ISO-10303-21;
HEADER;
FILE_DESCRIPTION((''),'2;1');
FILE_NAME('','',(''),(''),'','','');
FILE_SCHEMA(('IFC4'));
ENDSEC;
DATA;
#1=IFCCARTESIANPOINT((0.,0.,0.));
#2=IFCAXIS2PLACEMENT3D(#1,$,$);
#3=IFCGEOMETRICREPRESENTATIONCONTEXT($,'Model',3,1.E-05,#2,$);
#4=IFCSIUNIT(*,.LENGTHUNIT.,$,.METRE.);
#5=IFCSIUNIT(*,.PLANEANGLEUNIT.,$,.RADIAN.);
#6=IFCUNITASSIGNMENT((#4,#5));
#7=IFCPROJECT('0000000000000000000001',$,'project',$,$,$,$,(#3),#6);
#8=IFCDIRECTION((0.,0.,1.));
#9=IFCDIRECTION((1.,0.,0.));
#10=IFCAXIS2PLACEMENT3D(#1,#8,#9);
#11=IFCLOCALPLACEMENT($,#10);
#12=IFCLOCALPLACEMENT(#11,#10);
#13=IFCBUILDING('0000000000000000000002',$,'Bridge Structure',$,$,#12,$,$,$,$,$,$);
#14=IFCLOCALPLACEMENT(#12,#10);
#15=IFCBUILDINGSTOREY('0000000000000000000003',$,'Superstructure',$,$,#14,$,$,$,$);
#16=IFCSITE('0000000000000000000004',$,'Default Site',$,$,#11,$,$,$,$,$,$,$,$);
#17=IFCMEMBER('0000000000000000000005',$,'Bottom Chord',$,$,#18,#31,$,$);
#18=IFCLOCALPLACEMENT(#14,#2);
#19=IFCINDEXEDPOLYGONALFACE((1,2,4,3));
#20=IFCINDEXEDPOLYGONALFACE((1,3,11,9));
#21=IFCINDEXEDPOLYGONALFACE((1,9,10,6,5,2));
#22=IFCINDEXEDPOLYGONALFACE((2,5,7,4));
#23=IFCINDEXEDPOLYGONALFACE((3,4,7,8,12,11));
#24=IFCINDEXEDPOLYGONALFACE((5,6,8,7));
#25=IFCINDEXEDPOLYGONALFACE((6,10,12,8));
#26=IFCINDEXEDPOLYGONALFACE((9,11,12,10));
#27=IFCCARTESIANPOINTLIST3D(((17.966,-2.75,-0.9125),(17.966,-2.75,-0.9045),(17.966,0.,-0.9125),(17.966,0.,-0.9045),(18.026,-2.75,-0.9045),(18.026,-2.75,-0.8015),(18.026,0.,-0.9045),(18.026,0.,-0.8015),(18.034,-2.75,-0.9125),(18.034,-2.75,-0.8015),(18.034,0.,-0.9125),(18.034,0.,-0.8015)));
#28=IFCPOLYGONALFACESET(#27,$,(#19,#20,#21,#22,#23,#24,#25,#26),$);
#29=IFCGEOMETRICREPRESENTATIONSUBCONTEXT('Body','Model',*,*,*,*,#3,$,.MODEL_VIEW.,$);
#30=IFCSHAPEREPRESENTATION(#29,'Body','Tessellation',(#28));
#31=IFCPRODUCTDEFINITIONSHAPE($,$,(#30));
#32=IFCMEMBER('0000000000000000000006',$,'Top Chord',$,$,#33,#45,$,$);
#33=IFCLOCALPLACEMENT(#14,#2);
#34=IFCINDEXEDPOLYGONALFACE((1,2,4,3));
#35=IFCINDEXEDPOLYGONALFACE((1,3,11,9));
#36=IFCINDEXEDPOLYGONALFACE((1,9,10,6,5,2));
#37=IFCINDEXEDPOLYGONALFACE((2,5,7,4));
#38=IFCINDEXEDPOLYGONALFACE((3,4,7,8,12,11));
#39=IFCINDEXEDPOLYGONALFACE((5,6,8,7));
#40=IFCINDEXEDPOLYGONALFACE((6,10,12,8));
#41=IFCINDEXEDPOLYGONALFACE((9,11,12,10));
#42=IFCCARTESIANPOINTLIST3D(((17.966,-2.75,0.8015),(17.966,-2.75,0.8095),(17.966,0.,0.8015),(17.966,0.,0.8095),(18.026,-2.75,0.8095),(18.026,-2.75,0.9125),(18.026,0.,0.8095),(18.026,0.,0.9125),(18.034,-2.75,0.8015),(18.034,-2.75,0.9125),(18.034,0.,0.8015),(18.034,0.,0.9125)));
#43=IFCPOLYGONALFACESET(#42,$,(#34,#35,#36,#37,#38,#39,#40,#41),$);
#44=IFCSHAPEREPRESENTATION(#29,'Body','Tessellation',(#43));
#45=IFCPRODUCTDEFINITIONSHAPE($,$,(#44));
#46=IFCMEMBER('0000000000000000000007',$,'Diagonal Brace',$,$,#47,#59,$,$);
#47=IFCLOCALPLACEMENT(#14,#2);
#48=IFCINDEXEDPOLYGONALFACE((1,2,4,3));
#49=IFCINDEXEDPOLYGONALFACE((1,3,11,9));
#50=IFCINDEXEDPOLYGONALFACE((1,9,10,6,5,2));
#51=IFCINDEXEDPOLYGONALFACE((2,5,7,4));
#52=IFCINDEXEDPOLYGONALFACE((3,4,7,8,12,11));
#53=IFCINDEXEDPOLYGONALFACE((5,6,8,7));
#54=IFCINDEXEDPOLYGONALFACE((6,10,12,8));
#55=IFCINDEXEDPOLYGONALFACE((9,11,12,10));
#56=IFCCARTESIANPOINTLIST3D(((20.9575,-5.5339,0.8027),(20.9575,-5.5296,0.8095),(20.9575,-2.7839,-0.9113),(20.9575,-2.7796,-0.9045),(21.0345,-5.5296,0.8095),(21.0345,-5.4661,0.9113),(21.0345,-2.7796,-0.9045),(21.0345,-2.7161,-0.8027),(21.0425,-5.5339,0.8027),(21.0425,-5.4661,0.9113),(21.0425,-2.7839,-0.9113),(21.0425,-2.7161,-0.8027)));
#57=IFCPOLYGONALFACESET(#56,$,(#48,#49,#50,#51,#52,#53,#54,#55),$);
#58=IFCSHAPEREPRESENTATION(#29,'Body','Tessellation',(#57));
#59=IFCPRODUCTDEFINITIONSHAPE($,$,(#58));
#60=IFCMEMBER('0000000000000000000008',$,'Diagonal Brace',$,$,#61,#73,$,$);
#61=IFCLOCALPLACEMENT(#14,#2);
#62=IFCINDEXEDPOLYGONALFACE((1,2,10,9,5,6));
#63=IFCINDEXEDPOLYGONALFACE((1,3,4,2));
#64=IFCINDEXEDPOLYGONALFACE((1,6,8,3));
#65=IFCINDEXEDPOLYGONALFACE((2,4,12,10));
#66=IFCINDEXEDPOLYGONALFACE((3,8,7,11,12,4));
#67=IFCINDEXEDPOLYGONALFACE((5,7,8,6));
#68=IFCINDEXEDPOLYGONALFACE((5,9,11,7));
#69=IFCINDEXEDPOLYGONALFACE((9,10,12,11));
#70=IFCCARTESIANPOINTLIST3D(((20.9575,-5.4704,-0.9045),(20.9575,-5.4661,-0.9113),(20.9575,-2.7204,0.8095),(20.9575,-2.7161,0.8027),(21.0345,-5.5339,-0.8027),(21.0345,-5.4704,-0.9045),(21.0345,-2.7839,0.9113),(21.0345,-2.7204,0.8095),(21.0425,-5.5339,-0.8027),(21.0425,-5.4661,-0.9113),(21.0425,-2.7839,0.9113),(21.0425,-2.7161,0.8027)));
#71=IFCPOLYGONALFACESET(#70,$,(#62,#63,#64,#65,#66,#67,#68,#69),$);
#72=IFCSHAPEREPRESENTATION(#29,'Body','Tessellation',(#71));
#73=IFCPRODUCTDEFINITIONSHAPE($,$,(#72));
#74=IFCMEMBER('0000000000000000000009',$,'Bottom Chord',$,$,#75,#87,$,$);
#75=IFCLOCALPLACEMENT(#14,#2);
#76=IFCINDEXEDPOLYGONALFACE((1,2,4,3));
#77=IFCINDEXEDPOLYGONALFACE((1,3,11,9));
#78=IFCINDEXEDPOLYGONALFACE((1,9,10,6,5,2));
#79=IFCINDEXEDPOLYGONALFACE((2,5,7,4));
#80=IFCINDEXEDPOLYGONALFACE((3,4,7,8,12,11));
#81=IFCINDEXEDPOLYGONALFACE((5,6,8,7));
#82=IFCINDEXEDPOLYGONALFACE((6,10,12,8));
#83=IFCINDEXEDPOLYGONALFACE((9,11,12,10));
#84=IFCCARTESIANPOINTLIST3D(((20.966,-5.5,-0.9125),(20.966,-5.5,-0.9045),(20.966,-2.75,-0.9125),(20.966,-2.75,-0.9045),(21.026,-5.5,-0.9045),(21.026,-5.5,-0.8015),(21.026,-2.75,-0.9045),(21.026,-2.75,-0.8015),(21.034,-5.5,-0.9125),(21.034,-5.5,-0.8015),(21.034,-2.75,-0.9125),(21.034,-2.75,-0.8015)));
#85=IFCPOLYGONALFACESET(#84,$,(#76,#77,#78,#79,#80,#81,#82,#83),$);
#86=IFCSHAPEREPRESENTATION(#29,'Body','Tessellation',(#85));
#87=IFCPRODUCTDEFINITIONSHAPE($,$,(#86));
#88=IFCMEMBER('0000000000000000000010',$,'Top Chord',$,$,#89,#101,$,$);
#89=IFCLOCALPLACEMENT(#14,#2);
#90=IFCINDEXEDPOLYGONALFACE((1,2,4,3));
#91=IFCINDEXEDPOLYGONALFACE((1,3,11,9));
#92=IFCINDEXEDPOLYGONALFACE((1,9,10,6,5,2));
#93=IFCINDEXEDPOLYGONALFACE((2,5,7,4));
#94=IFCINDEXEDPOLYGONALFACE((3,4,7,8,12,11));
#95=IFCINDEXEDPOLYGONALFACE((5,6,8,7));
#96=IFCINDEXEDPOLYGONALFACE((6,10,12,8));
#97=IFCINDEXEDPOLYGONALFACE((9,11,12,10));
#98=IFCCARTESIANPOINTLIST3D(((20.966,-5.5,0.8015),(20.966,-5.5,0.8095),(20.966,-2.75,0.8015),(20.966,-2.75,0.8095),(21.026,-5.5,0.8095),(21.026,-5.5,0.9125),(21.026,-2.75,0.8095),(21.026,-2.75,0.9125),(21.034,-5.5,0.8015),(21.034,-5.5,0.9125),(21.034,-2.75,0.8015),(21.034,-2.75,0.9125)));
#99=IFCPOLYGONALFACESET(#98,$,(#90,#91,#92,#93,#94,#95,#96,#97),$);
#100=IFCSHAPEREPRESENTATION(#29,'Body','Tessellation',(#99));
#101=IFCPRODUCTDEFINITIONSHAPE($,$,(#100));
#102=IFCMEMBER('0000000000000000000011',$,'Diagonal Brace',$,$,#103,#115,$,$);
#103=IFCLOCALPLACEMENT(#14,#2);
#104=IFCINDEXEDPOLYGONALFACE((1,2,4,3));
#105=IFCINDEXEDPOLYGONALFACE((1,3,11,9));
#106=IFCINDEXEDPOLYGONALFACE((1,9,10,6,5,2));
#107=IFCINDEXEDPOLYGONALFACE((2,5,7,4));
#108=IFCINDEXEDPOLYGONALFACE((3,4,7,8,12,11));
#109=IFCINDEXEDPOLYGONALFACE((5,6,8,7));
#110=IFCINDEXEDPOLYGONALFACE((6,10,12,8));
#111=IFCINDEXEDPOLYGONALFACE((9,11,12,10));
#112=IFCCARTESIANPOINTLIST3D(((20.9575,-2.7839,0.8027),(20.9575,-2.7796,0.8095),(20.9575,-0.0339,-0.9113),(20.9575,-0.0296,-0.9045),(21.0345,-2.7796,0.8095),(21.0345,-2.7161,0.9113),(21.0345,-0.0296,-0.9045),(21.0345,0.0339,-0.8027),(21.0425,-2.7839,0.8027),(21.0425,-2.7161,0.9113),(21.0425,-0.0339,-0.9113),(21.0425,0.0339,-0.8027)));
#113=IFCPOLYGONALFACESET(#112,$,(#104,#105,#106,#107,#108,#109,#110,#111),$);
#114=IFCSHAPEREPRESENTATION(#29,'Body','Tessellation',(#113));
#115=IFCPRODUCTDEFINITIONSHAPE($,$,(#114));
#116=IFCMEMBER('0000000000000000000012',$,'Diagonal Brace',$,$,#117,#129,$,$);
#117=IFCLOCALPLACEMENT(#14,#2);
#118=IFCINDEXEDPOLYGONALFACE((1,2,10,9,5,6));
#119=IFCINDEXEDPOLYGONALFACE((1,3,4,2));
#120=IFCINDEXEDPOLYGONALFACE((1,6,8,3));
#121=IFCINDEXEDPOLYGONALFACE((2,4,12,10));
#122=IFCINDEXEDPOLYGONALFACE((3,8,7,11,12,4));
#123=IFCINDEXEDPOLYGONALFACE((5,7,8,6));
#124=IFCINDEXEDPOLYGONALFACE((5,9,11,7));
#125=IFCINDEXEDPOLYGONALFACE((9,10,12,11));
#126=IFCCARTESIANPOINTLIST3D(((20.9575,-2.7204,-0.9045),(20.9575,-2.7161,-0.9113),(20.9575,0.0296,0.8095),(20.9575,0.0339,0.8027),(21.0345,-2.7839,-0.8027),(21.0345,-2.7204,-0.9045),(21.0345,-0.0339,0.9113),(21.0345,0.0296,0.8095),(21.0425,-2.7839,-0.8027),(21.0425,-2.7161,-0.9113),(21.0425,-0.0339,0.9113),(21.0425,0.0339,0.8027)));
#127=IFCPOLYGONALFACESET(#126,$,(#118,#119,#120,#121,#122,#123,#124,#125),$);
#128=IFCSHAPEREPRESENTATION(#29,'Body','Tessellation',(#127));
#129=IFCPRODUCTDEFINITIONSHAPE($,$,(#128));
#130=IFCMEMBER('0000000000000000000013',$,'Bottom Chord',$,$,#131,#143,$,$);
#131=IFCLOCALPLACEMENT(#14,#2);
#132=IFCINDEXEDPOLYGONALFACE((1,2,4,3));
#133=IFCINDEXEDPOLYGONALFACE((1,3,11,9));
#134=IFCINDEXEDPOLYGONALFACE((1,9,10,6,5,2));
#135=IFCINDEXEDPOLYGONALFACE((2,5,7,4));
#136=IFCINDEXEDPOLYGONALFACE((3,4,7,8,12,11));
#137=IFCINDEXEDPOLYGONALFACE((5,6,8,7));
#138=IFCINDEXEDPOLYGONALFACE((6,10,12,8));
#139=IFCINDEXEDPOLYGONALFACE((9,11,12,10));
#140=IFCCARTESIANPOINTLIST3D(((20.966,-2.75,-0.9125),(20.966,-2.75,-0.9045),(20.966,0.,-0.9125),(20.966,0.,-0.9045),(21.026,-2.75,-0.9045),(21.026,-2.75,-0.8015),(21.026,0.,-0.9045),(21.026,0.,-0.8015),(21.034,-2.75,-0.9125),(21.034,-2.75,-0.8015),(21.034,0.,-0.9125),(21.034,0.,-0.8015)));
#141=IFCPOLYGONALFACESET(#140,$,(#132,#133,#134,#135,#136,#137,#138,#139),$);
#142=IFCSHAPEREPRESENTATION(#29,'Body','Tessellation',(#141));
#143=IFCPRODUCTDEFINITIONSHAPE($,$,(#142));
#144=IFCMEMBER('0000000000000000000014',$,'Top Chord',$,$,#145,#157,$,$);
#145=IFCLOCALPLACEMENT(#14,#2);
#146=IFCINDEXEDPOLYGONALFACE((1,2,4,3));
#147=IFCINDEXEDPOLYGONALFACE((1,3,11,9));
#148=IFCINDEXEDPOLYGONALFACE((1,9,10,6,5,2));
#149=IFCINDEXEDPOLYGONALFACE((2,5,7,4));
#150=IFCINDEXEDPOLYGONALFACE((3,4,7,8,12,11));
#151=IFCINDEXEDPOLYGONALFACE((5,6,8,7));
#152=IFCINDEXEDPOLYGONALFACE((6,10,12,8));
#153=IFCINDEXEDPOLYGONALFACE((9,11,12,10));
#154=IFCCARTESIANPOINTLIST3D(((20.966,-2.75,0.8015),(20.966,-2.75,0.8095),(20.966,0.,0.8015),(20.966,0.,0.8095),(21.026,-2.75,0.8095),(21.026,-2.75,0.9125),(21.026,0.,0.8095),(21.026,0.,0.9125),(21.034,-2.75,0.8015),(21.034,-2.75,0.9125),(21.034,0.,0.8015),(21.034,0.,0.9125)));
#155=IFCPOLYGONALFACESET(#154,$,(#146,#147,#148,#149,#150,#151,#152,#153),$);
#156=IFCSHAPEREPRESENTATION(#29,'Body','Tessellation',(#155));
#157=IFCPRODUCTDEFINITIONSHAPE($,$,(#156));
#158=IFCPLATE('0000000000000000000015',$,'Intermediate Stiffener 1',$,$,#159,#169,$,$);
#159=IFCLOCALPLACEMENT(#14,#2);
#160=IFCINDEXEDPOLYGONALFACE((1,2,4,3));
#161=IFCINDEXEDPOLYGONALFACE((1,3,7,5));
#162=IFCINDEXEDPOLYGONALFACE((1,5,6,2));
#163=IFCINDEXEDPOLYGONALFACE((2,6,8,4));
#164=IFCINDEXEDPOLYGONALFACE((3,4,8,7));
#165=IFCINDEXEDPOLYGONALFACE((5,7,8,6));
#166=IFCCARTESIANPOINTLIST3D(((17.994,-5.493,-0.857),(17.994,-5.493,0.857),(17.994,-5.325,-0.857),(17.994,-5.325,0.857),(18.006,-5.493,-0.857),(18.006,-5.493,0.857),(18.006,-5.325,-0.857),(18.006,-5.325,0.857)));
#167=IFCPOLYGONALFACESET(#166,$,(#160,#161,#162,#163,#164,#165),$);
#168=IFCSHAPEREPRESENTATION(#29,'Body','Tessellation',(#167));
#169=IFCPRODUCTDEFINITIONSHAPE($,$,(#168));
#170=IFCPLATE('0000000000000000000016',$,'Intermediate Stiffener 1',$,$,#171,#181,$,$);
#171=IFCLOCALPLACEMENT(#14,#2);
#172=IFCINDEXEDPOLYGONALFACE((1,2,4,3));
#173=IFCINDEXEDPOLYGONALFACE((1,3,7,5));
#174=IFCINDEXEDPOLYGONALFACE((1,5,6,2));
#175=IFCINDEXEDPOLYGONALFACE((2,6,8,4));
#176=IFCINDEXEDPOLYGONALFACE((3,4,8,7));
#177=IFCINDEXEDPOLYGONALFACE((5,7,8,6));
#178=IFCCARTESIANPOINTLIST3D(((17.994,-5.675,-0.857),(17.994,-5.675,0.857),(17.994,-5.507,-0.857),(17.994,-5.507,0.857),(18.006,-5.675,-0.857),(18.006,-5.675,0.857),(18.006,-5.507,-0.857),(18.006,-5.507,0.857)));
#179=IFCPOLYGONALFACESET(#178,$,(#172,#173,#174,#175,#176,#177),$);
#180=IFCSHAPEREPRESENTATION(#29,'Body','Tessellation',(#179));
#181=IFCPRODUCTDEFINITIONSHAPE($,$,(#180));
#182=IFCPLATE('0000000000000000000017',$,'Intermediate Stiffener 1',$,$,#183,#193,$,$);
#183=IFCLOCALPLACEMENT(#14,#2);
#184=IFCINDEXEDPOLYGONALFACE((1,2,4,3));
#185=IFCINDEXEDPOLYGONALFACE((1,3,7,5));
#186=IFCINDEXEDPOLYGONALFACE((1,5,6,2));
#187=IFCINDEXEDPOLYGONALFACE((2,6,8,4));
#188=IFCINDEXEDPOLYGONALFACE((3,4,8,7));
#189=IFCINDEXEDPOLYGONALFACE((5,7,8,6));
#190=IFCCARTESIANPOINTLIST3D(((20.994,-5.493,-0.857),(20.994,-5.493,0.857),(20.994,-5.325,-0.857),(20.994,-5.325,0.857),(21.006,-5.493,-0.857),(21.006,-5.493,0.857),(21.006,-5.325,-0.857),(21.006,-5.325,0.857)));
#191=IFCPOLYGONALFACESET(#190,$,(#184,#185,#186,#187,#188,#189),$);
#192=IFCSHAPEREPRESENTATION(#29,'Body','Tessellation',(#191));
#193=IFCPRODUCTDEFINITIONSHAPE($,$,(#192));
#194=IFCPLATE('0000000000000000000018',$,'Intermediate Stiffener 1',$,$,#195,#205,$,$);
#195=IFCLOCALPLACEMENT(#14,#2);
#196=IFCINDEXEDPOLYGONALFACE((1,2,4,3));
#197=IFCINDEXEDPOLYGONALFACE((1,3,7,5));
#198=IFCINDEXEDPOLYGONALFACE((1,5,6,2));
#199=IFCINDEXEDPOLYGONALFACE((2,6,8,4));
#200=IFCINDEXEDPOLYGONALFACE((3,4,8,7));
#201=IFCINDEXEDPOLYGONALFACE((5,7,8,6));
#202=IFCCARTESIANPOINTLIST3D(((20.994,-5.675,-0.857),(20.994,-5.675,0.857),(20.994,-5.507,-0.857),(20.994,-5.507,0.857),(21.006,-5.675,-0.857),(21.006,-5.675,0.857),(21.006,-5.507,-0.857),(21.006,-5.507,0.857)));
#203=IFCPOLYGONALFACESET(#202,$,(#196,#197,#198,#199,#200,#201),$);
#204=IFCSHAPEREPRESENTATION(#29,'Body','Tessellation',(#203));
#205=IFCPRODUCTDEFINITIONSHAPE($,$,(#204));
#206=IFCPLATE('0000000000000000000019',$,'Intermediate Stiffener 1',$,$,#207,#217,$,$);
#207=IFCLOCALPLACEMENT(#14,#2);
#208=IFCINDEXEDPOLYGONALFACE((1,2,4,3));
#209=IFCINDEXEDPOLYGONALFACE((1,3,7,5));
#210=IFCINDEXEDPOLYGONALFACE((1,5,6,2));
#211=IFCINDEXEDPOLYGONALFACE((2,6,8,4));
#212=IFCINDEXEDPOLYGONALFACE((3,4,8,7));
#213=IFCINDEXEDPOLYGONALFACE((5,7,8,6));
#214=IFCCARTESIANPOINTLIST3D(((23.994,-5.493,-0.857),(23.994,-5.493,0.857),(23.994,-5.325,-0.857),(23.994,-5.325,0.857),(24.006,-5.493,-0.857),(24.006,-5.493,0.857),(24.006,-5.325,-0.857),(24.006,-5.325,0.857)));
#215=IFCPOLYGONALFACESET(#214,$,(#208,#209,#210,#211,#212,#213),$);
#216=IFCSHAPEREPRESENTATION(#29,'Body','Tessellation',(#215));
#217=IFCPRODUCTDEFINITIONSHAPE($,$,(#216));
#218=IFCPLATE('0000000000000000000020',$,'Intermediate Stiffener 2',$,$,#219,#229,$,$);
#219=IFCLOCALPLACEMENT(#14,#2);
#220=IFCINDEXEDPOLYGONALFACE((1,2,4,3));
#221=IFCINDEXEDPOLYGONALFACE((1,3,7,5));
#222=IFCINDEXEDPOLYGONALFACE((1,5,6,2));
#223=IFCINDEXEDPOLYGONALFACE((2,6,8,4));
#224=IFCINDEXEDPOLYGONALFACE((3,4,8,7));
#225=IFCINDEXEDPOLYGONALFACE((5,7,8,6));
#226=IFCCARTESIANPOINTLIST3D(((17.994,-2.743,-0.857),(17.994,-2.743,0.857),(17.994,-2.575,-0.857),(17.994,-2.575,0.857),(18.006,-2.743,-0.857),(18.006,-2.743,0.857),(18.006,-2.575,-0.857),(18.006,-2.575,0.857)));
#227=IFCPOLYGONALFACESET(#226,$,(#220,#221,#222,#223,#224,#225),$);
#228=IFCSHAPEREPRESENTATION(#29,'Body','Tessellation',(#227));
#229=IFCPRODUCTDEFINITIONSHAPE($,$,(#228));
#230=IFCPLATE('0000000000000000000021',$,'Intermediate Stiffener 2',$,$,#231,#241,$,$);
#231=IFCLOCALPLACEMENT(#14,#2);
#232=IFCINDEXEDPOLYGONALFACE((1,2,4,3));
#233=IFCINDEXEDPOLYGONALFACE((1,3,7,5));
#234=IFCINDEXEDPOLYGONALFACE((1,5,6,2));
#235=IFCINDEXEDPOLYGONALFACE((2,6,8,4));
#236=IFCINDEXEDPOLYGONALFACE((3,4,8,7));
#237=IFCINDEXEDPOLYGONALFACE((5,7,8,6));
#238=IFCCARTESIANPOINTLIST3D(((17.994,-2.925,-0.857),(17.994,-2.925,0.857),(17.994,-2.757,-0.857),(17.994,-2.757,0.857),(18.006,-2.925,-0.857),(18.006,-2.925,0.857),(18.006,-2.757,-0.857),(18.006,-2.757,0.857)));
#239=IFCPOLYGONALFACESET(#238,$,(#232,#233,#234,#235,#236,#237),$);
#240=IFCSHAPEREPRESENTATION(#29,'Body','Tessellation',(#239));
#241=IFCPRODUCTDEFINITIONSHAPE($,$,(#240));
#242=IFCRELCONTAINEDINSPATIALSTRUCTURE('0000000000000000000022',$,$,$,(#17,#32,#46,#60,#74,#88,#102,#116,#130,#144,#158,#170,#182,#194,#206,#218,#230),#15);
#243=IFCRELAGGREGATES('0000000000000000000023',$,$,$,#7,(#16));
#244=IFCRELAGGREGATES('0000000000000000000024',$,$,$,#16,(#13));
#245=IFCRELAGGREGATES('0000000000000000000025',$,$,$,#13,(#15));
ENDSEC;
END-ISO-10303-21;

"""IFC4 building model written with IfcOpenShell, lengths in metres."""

from ifc_helpers import new_model, si_unit, frame, origin, origin_with_axes, origin_2d_with_axis, place, context, subcontext, project, spatial, rectangle, l_section, extrude, element, save


model = new_model("IFC4")

# Units and contexts
model_context = context("Model", 3, precision=1e-05, world=origin())
body_context = subcontext(model_context, "Body", "Model", "MODEL_VIEW")
ifc_project = project(units=[si_unit("LENGTHUNIT", "METRE"), si_unit("PLANEANGLEUNIT", "RADIAN")], contexts=[model_context])

# Site, building, storey
site_placement = place(None, origin_with_axes())
site = spatial("IfcSite", under=ifc_project, at=site_placement, Name="Default Site")
building_placement = place(site_placement, origin_with_axes())
building = spatial("IfcBuilding", under=site, at=building_placement, Name="Bridge Structure")
storey_placement = place(building_placement, origin_with_axes())
storey = spatial("IfcBuildingStorey", under=building, at=storey_placement, Name="Superstructure")

# Members
for number, where, z_axis, x_axis, name in (
    (1, (18.0, -2.75, -0.857), (0.0, 1.0, 0.0), (-1.0, 0.0, 0.0), "Bottom Chord"),
    (2, (18.0, -2.75, 0.857), (0.0, 1.0, 0.0), (-1.0, 0.0, 0.0), "Top Chord"),
):
    element("IfcMember", number, at=place(storey_placement, frame(where, z_axis=z_axis, x_axis=x_axis)), inside=storey, Name=name, context=body_context, shape_type="SweptSolid", body=[
        extrude(l_section(Depth=0.111, Width=0.068, Thickness=0.008, at=origin_2d_with_axis()), origin_with_axes(), (0.0, 0.0, 1.0), 2.75),
    ])
for number, where, z_axis, x_axis, name in (
    (3, (21.0, -5.5, 0.857), (0.0, 0.848656, -0.528944), (-1.0, 0.0, 0.0), "Diagonal Brace"),
    (4, (21.0, -5.5, -0.857), (0.0, 0.848656, 0.528944), (-1.0, 0.0, 0.0), "Diagonal Brace"),
):
    element("IfcMember", number, at=place(storey_placement, frame(where, z_axis=z_axis, x_axis=x_axis)), inside=storey, Name=name, context=body_context, shape_type="SweptSolid", body=[
        extrude(l_section(Depth=0.128, Width=0.085, Thickness=0.008, at=origin_2d_with_axis()), origin_with_axes(), (0.0, 0.0, 1.0), 3.2404),
    ])
for number, where, z_axis, x_axis, name in (
    (5, (21.0, -5.5, -0.857), (0.0, 1.0, 0.0), (-1.0, 0.0, 0.0), "Bottom Chord"),
    (6, (21.0, -5.5, 0.857), (0.0, 1.0, 0.0), (-1.0, 0.0, 0.0), "Top Chord"),
):
    element("IfcMember", number, at=place(storey_placement, frame(where, z_axis=z_axis, x_axis=x_axis)), inside=storey, Name=name, context=body_context, shape_type="SweptSolid", body=[
        extrude(l_section(Depth=0.111, Width=0.068, Thickness=0.008, at=origin_2d_with_axis()), origin_with_axes(), (0.0, 0.0, 1.0), 2.75),
    ])
for number, where, z_axis, x_axis, name in (
    (7, (21.0, -2.75, 0.857), (0.0, 0.848656, -0.528944), (-1.0, 0.0, 0.0), "Diagonal Brace"),
    (8, (21.0, -2.75, -0.857), (0.0, 0.848656, 0.528944), (-1.0, 0.0, 0.0), "Diagonal Brace"),
):
    element("IfcMember", number, at=place(storey_placement, frame(where, z_axis=z_axis, x_axis=x_axis)), inside=storey, Name=name, context=body_context, shape_type="SweptSolid", body=[
        extrude(l_section(Depth=0.128, Width=0.085, Thickness=0.008, at=origin_2d_with_axis()), origin_with_axes(), (0.0, 0.0, 1.0), 3.2404),
    ])
for number, where, z_axis, x_axis, name in (
    (9, (21.0, -2.75, -0.857), (0.0, 1.0, 0.0), (-1.0, 0.0, 0.0), "Bottom Chord"),
    (10, (21.0, -2.75, 0.857), (0.0, 1.0, 0.0), (-1.0, 0.0, 0.0), "Top Chord"),
):
    element("IfcMember", number, at=place(storey_placement, frame(where, z_axis=z_axis, x_axis=x_axis)), inside=storey, Name=name, context=body_context, shape_type="SweptSolid", body=[
        extrude(l_section(Depth=0.111, Width=0.068, Thickness=0.008, at=origin_2d_with_axis()), origin_with_axes(), (0.0, 0.0, 1.0), 2.75),
    ])

# Plates
for number, where, z_axis, x_axis, name in (
    (11, (18.0, -5.409, -0.857), (0.0, 0.0, 1.0), (1.0, 0.0, 0.0), "Intermediate Stiffener 1"),
    (12, (18.0, -5.591, -0.857), (0.0, 0.0, 1.0), (1.0, 0.0, 0.0), "Intermediate Stiffener 1"),
    (13, (21.0, -5.409, -0.857), (0.0, 0.0, 1.0), (1.0, 0.0, 0.0), "Intermediate Stiffener 1"),
    (14, (21.0, -5.591, -0.857), (0.0, 0.0, 1.0), (1.0, 0.0, 0.0), "Intermediate Stiffener 1"),
    (15, (24.0, -5.409, -0.857), (0.0, 0.0, 1.0), (1.0, 0.0, 0.0), "Intermediate Stiffener 1"),
    (16, (18.0, -2.659, -0.857), (0.0, 0.0, 1.0), (1.0, 0.0, 0.0), "Intermediate Stiffener 2"),
    (17, (18.0, -2.841, -0.857), (0.0, 0.0, 1.0), (1.0, 0.0, 0.0), "Intermediate Stiffener 2"),
):
    element("IfcPlate", number, at=place(storey_placement, frame(where, z_axis=z_axis, x_axis=x_axis)), inside=storey, Name=name, context=body_context, shape_type="SweptSolid", body=[
        extrude(rectangle(XDim=0.012, YDim=0.168, at=origin_2d_with_axis()), origin_with_axes(), (0.0, 0.0, 1.0), 1.714),
    ])

save(model, "model.ifc")
